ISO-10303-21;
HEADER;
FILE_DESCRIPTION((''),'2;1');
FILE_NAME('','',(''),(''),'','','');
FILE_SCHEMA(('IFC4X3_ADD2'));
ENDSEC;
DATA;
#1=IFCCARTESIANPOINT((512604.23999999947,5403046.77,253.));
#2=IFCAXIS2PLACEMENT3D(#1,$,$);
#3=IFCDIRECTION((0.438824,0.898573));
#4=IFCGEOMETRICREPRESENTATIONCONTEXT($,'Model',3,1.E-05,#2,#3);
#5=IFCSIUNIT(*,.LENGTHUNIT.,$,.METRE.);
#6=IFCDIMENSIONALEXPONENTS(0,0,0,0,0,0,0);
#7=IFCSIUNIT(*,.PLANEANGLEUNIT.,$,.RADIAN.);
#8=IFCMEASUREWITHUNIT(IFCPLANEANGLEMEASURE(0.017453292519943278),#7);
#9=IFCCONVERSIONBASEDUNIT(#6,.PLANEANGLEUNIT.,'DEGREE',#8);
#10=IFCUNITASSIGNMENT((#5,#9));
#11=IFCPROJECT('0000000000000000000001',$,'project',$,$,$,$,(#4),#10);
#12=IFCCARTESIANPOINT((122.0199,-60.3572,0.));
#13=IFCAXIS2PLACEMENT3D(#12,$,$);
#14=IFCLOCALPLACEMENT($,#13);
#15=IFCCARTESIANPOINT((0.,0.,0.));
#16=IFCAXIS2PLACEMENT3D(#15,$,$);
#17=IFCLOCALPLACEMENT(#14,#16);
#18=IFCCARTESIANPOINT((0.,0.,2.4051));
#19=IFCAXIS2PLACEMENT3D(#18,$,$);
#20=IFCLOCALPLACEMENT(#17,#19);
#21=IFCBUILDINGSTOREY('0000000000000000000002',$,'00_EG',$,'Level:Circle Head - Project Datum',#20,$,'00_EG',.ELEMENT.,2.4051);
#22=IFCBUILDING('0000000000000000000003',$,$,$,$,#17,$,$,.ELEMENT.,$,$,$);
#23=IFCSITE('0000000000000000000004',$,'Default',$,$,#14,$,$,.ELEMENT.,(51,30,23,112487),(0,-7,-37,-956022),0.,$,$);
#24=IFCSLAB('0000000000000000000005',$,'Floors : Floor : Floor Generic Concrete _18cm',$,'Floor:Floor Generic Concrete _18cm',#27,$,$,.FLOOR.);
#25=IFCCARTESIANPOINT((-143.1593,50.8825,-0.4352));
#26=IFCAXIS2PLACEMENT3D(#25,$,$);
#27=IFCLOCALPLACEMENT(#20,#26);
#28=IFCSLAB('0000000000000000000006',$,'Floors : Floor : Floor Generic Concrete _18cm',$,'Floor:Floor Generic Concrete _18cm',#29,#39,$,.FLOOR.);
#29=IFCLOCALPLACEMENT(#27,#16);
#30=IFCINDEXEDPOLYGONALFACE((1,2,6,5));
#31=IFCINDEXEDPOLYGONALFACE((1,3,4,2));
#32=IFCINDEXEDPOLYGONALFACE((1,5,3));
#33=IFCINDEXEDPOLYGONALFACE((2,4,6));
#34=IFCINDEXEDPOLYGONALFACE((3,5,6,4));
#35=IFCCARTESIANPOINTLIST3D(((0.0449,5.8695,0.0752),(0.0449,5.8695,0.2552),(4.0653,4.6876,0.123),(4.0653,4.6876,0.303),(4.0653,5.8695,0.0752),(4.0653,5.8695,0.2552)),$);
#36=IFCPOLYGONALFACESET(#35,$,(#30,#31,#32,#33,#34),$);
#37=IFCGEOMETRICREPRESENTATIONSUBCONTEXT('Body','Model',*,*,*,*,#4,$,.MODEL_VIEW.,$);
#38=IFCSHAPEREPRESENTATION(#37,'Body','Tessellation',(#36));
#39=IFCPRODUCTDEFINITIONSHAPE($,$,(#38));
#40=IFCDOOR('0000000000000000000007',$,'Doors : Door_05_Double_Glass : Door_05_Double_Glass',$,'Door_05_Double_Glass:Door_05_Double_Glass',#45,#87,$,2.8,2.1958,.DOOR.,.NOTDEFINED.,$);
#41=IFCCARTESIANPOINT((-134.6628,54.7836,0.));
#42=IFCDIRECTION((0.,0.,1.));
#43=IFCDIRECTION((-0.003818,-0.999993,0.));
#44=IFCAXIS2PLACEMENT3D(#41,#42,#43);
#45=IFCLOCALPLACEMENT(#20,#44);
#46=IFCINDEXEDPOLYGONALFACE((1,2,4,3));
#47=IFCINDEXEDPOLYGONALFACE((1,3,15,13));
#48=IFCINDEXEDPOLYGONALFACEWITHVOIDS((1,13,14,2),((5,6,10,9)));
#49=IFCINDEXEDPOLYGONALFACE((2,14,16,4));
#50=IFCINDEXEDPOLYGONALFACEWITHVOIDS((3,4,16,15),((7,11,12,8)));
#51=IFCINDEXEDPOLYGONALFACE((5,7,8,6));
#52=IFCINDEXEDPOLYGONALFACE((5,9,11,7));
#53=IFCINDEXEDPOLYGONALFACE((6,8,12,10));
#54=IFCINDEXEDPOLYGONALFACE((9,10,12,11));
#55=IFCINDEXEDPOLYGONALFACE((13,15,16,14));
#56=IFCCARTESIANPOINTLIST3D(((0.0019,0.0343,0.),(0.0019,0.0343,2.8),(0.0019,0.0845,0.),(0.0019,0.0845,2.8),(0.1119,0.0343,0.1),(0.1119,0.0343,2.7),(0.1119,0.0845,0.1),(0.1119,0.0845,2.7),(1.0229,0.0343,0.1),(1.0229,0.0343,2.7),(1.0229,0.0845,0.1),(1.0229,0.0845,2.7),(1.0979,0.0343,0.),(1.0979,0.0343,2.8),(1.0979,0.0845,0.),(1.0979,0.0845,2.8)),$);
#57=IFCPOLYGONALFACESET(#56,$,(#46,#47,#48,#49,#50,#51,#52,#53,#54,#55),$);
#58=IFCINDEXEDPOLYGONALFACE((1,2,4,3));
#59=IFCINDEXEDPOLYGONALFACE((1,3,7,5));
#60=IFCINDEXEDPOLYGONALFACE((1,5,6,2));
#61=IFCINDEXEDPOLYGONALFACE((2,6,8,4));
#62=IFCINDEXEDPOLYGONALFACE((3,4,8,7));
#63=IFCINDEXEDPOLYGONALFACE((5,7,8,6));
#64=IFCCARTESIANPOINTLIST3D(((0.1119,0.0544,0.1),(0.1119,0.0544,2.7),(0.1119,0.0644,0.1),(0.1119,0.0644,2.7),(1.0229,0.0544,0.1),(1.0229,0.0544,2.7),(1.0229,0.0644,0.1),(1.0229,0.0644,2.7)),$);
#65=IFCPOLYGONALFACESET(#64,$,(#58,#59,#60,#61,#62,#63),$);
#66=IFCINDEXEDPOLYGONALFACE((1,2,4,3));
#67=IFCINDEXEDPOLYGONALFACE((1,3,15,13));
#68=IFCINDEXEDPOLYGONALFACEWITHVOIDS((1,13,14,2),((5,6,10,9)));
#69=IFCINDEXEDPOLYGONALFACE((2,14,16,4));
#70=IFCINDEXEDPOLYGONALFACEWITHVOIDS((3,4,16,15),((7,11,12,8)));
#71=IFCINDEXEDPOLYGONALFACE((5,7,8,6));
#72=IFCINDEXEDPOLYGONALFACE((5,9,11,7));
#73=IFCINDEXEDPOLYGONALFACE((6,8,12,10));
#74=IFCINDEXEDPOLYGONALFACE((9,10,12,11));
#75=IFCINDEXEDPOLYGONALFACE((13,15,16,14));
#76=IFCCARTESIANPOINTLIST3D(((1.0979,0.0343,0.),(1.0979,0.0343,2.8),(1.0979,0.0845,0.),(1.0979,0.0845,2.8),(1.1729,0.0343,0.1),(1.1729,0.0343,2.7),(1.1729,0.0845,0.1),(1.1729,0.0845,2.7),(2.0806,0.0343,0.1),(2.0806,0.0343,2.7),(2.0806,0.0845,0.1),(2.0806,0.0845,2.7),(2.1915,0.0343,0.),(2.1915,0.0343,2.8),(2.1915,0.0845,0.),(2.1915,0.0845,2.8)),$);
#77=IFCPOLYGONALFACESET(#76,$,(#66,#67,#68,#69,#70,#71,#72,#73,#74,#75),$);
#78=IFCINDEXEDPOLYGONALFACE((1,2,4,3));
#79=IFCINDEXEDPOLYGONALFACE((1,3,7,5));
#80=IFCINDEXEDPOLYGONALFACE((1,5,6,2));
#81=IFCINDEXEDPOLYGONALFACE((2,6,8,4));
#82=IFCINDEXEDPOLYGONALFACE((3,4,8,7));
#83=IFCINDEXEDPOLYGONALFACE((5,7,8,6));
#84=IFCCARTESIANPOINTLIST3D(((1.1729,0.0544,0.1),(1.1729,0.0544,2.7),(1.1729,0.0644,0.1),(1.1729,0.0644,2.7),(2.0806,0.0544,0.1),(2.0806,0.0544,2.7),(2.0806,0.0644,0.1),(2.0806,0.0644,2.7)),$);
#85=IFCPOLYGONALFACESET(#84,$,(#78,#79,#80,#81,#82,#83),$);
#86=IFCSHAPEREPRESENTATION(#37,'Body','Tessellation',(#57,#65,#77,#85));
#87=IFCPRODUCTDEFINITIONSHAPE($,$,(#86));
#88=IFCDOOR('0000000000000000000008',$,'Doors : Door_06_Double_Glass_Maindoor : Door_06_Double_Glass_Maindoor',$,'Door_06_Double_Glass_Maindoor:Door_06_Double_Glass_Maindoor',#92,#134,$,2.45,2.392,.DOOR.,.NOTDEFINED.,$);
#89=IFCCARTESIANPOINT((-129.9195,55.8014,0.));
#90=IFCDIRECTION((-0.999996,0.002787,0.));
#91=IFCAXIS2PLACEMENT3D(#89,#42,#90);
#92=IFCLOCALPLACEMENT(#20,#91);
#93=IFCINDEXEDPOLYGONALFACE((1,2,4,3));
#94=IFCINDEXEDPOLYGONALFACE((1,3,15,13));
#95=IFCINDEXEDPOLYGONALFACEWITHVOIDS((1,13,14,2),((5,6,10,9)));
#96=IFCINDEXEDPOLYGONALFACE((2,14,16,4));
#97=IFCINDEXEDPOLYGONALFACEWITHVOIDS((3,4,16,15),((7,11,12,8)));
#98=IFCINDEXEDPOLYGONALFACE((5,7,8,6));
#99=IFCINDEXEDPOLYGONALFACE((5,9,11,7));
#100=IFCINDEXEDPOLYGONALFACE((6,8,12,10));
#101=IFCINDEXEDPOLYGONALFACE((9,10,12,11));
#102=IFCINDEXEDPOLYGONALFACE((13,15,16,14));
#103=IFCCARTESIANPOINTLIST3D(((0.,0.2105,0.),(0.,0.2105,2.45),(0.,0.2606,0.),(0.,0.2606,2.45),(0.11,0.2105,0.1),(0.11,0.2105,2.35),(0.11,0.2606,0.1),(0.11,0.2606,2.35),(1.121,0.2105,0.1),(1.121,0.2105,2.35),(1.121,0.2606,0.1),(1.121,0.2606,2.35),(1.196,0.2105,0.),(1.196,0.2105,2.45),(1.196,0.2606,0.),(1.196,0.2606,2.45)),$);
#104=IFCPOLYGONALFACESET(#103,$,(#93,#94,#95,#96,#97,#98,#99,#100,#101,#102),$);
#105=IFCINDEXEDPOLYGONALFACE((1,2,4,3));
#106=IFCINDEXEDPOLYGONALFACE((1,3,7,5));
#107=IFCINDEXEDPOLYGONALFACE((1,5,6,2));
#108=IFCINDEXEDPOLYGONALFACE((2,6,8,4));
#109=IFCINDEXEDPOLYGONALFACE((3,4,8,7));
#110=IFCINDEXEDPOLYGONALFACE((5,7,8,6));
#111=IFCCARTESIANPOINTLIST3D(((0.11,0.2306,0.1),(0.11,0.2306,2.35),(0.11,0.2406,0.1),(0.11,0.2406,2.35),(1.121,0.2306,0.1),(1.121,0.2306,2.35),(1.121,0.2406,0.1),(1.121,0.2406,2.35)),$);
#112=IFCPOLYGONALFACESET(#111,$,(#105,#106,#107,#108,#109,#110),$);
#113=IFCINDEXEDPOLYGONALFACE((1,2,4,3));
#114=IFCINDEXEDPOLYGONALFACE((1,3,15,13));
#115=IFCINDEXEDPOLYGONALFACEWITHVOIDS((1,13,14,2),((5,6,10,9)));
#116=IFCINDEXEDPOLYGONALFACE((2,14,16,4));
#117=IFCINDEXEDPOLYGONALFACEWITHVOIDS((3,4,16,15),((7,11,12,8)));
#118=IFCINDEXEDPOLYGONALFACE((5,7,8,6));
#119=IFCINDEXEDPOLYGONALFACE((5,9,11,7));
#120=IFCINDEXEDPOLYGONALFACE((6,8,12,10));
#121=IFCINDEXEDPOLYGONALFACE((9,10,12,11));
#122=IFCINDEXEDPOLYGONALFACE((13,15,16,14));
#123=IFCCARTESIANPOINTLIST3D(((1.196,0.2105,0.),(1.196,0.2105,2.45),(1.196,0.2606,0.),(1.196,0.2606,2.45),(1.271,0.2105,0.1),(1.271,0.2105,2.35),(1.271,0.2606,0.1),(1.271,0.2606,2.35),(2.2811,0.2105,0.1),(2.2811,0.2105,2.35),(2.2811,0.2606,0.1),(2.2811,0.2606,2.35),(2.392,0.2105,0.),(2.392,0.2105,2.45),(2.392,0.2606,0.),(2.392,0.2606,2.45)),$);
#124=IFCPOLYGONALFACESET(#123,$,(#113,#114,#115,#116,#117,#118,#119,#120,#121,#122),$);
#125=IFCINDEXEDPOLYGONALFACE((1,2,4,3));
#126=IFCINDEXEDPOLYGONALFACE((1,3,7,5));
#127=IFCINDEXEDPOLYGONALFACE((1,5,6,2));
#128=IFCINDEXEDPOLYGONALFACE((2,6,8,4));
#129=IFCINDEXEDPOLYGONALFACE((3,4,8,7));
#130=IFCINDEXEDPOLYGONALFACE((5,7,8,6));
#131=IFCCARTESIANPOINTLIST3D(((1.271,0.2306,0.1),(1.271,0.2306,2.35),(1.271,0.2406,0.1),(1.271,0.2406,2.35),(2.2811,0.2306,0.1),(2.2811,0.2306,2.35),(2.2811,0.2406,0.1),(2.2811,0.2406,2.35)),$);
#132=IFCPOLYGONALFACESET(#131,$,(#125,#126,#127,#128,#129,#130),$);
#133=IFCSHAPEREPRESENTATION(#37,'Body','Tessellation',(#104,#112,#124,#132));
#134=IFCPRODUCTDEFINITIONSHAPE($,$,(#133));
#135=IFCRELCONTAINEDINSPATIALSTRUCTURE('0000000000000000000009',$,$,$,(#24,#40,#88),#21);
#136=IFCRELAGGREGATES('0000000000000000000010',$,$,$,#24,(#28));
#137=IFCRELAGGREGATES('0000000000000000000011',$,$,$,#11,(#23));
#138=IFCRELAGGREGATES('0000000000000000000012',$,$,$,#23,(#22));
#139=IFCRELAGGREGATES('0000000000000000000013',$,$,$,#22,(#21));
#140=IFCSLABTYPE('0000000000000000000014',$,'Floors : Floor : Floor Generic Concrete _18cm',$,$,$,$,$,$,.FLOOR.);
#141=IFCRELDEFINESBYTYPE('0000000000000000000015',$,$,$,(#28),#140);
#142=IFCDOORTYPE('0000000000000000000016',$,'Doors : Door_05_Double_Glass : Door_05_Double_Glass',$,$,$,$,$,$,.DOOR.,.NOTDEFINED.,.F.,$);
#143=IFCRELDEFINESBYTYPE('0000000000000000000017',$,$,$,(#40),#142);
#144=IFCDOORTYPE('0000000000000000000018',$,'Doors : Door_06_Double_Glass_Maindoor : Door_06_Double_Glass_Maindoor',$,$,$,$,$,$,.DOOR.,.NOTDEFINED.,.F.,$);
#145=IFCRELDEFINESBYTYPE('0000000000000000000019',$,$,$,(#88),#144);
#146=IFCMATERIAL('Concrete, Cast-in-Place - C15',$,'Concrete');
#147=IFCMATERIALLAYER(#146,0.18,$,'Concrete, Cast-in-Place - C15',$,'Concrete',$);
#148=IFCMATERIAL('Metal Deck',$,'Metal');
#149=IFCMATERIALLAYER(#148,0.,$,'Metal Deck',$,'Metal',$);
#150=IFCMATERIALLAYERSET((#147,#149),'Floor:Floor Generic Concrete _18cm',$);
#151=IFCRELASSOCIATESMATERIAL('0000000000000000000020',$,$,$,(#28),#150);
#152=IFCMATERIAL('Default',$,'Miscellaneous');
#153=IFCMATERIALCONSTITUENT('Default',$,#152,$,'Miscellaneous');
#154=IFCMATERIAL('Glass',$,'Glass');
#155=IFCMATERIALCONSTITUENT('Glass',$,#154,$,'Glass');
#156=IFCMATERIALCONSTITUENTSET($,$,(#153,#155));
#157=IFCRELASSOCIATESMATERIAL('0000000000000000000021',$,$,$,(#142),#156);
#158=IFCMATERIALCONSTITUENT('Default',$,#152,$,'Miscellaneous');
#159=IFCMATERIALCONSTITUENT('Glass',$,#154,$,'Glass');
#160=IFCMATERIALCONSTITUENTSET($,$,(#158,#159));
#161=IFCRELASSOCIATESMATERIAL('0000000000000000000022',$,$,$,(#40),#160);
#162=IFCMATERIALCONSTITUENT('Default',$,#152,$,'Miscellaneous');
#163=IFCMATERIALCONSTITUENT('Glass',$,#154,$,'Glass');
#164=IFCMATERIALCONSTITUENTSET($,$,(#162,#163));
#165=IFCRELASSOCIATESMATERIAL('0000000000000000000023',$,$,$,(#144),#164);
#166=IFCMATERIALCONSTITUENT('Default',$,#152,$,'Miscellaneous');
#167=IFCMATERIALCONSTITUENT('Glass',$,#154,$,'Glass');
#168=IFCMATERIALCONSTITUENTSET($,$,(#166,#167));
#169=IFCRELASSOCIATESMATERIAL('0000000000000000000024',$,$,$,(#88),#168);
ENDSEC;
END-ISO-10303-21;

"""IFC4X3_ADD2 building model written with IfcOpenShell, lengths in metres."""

from ifc_helpers import new_model, entity, si_unit, converted_unit, direction, frame, frame_2d, origin, origin_2d_with_axis, place, context, subcontext, project, spatial, polyline, rectangle, outline, extrude, source, transform, mapped, material, layer, layer_set, constituent, constituent_set, type_object, type_shapes, element, aggregate, save


model = new_model("IFC4X3_ADD2")

# Units and contexts
model_context = context("Model", 3, precision=1e-05, world=frame((512604.23999999947, 5403046.77, 253.0)), true_north=direction((0.438824, 0.898573)))
body_context = subcontext(model_context, "Body", "Model", "MODEL_VIEW")
ifc_project = project(units=[si_unit("LENGTHUNIT", "METRE"), converted_unit("PLANEANGLEUNIT", "DEGREE", entity("IfcPlaneAngleMeasure", 0.017453292519943278), si_unit("PLANEANGLEUNIT", "RADIAN"), dimensions=[0, 0, 0, 0, 0, 0, 0])], contexts=[model_context])

# Site, building, storey
site_placement = place(None, frame((122.0199, -60.3572, 0.0)))
site = spatial("IfcSite", under=ifc_project, at=site_placement, Name="Default", CompositionType="ELEMENT", RefLatitude=(51, 30, 23, 112487), RefLongitude=(0, -7, -37, -956022), RefElevation=0.0)
building_placement = place(site_placement, origin())
building = spatial("IfcBuilding", under=site, at=building_placement, CompositionType="ELEMENT")
storey_placement = place(building_placement, frame((0.0, 0.0, 2.4051)))
storey = spatial("IfcBuildingStorey", under=building, at=storey_placement, Name="00_EG", ObjectType="Level:Circle Head - Project Datum", LongName="00_EG", CompositionType="ELEMENT", Elevation=2.4051)

# Slabs
slab_1_placement = place(storey_placement, frame((-143.1593, 50.8825, -0.4352)))
slab_1 = element("IfcSlab", 1, at=slab_1_placement, inside=storey, Name="Floors : Floor : Floor Generic Concrete _18cm", ObjectType="Floor:Floor Generic Concrete _18cm", PredefinedType="FLOOR")
ifc_material_1 = material(Name="Concrete, Cast-in-Place - C15", Category="Concrete")
ifc_layer_1 = layer(ifc_material_1, 0.18, Name="Concrete, Cast-in-Place - C15", Category="Concrete")
ifc_material_2 = material(Name="Metal Deck", Category="Metal")
ifc_layer_2 = layer(ifc_material_2, 0.0, Name="Metal Deck", Category="Metal")
ifc_layer_set_1 = layer_set([ifc_layer_1, ifc_layer_2], Name="Floor:Floor Generic Concrete _18cm")
slab_type = type_object("IfcSlabType", Name="Floors : Floor : Floor Generic Concrete _18cm", PredefinedType="FLOOR")
slab_2_placement = place(slab_1_placement, origin())
slab_2 = element("IfcSlab", 2, at=slab_2_placement, type_object=slab_type, material=ifc_layer_set_1, Name="Floors : Floor : Floor Generic Concrete _18cm", ObjectType="Floor:Floor Generic Concrete _18cm", PredefinedType="FLOOR", context=body_context, shape_type="SweptSolid", body=[
    extrude(outline(polyline([(2.0102, -0.5915), (2.0102, 0.5915), (-2.0102, 0.5915), (2.0102, -0.5915)])), frame((2.0551, 5.2785, 0.2791), z_axis=(0.0, 0.040407, 0.999183), x_axis=(1.0, 0.0, 0.0)), (0.0, 0.040407, -0.999183), 0.18),
])
aggregate(slab_1, [slab_2])

# Door
ifc_material_3 = material(Name="Default", Category="Miscellaneous")
ifc_material_4 = material(Name="Glass", Category="Glass")
ifc_constituent_1 = constituent(ifc_material_3, Name="Default", Category="Miscellaneous")
ifc_constituent_2 = constituent(ifc_material_4, Name="Glass", Category="Glass")
ifc_constituent_set_1 = constituent_set(constituents=[ifc_constituent_1, ifc_constituent_2])
ifc_constituent_3 = constituent(ifc_material_3, Name="Default", Category="Miscellaneous")
ifc_constituent_4 = constituent(ifc_material_4, Name="Glass", Category="Glass")
ifc_constituent_set_2 = constituent_set(constituents=[ifc_constituent_3, ifc_constituent_4])
door_type_1 = type_object("IfcDoorType", Name="Doors : Door_05_Double_Glass : Door_05_Double_Glass", OperationType="NOTDEFINED", ParameterTakesPrecedence=False, PredefinedType="DOOR", material=ifc_constituent_set_2)
shared_shape_1 = source(origin(), body_context, "Body", "SweptSolid", [
    extrude(outline(polyline([(-1.4, -0.548), (1.4, -0.548), (1.4, 0.548), (-1.4, 0.548), (-1.4, -0.548)]), holes=[polyline([(1.3, 0.438), (1.3, -0.473), (-1.3, -0.473), (-1.3, 0.438), (1.3, 0.438)])]), frame((0.5499, 0.0343, 1.4), z_axis=(0.0, 1.0, 0.0), x_axis=(0.0, 0.0, -1.0)), (0.0, 0.0, 1.0), 0.0501),
    extrude(rectangle(XDim=0.911, YDim=0.01, at=frame_2d((0.0, 0.0), x_axis=(1.0, 0.0))), frame((0.5674, 0.0594, 0.1)), (0.0, 0.0, 1.0), 2.6),
    extrude(outline(polyline([(-0.5468, -1.4), (0.5468, -1.4), (0.5468, 1.4), (-0.5468, 1.4), (-0.5468, -1.4)]), holes=[polyline([(0.4359, 1.3), (0.4359, -1.3), (-0.4718, -1.3), (-0.4718, 1.3), (0.4359, 1.3)])]), frame((1.6447, 0.0343, 1.4), z_axis=(0.0, 1.0, 0.0), x_axis=(1.0, 0.0, 0.0)), (0.0, 0.0, 1.0), 0.0501),
    extrude(rectangle(XDim=0.01, YDim=0.9078, at=frame_2d((0.0, 0.0), x_axis=(1.0, 0.0))), frame((1.6268, 0.0594, 0.1), z_axis=(0.0, 0.0, 1.0), x_axis=(0.0, 1.0, 0.0)), (0.0, 0.0, 1.0), 2.6),
])
type_shapes(door_type_1, [shared_shape_1])
door_1_placement = place(storey_placement, frame((-134.6628, 54.7836, 0.0), z_axis=(0.0, 0.0, 1.0), x_axis=(-0.003818, -0.999993, 0.0)))
element("IfcDoor", 3, at=door_1_placement, inside=storey, type_object=door_type_1, material=ifc_constituent_set_1, Name="Doors : Door_05_Double_Glass : Door_05_Double_Glass", ObjectType="Door_05_Double_Glass:Door_05_Double_Glass", OperationType="NOTDEFINED", OverallHeight=2.8, OverallWidth=2.1958, PredefinedType="DOOR", context=body_context, shape_type="MappedRepresentation", body=[
    mapped(shared_shape_1, transform((0.0, 0.0, 0.0), scale=1.0)),
])

# Door
ifc_constituent_5 = constituent(ifc_material_3, Name="Default", Category="Miscellaneous")
ifc_constituent_6 = constituent(ifc_material_4, Name="Glass", Category="Glass")
ifc_constituent_set_3 = constituent_set(constituents=[ifc_constituent_5, ifc_constituent_6])
ifc_constituent_7 = constituent(ifc_material_3, Name="Default", Category="Miscellaneous")
ifc_constituent_8 = constituent(ifc_material_4, Name="Glass", Category="Glass")
ifc_constituent_set_4 = constituent_set(constituents=[ifc_constituent_7, ifc_constituent_8])
door_type_2 = type_object("IfcDoorType", Name="Doors : Door_06_Double_Glass_Maindoor : Door_06_Double_Glass_Maindoor", OperationType="NOTDEFINED", ParameterTakesPrecedence=False, PredefinedType="DOOR", material=ifc_constituent_set_4)
shared_shape_2 = source(origin(), body_context, "Body", "SweptSolid", [
    extrude(outline(polyline([(-1.225, -0.598), (1.225, -0.598), (1.225, 0.598), (-1.225, 0.598), (-1.225, -0.598)]), holes=[polyline([(1.125, 0.488), (1.125, -0.523), (-1.125, -0.523), (-1.125, 0.488), (1.125, 0.488)])]), frame((0.598, 0.2105, 1.225), z_axis=(0.0, 1.0, 0.0), x_axis=(0.0, 0.0, -1.0)), (0.0, 0.0, 1.0), 0.0501),
    extrude(rectangle(XDim=1.011, YDim=0.01, at=origin_2d_with_axis()), frame((0.6155, 0.2356, 0.1)), (0.0, 0.0, 1.0), 2.25),
    extrude(outline(polyline([(-0.598, -1.225), (0.598, -1.225), (0.598, 1.225), (-0.598, 1.225), (-0.598, -1.225)]), holes=[polyline([(0.4871, 1.125), (0.4871, -1.125), (-0.523, -1.125), (-0.523, 1.125), (0.4871, 1.125)])]), frame((1.794, 0.2105, 1.225), z_axis=(0.0, 1.0, 0.0), x_axis=(1.0, 0.0, 0.0)), (0.0, 0.0, 1.0), 0.0501),
    extrude(rectangle(XDim=0.01, YDim=1.0101, at=frame_2d((0.0, 0.0), x_axis=(1.0, 0.0))), frame((1.776, 0.2356, 0.1), z_axis=(0.0, 0.0, 1.0), x_axis=(0.0, 1.0, 0.0)), (0.0, 0.0, 1.0), 2.25),
])
type_shapes(door_type_2, [shared_shape_2])
door_2_placement = place(storey_placement, frame((-129.9195, 55.8014, 0.0), z_axis=(0.0, 0.0, 1.0), x_axis=(-0.999996, 0.002787, 0.0)))
element("IfcDoor", 4, at=door_2_placement, inside=storey, type_object=door_type_2, material=ifc_constituent_set_3, Name="Doors : Door_06_Double_Glass_Maindoor : Door_06_Double_Glass_Maindoor", ObjectType="Door_06_Double_Glass_Maindoor:Door_06_Double_Glass_Maindoor", OperationType="NOTDEFINED", OverallHeight=2.45, OverallWidth=2.392, PredefinedType="DOOR", context=body_context, shape_type="MappedRepresentation", body=[
    mapped(shared_shape_2, transform((0.0, 0.0, 0.0), scale=1.0)),
])

save(model, "model.ifc")
